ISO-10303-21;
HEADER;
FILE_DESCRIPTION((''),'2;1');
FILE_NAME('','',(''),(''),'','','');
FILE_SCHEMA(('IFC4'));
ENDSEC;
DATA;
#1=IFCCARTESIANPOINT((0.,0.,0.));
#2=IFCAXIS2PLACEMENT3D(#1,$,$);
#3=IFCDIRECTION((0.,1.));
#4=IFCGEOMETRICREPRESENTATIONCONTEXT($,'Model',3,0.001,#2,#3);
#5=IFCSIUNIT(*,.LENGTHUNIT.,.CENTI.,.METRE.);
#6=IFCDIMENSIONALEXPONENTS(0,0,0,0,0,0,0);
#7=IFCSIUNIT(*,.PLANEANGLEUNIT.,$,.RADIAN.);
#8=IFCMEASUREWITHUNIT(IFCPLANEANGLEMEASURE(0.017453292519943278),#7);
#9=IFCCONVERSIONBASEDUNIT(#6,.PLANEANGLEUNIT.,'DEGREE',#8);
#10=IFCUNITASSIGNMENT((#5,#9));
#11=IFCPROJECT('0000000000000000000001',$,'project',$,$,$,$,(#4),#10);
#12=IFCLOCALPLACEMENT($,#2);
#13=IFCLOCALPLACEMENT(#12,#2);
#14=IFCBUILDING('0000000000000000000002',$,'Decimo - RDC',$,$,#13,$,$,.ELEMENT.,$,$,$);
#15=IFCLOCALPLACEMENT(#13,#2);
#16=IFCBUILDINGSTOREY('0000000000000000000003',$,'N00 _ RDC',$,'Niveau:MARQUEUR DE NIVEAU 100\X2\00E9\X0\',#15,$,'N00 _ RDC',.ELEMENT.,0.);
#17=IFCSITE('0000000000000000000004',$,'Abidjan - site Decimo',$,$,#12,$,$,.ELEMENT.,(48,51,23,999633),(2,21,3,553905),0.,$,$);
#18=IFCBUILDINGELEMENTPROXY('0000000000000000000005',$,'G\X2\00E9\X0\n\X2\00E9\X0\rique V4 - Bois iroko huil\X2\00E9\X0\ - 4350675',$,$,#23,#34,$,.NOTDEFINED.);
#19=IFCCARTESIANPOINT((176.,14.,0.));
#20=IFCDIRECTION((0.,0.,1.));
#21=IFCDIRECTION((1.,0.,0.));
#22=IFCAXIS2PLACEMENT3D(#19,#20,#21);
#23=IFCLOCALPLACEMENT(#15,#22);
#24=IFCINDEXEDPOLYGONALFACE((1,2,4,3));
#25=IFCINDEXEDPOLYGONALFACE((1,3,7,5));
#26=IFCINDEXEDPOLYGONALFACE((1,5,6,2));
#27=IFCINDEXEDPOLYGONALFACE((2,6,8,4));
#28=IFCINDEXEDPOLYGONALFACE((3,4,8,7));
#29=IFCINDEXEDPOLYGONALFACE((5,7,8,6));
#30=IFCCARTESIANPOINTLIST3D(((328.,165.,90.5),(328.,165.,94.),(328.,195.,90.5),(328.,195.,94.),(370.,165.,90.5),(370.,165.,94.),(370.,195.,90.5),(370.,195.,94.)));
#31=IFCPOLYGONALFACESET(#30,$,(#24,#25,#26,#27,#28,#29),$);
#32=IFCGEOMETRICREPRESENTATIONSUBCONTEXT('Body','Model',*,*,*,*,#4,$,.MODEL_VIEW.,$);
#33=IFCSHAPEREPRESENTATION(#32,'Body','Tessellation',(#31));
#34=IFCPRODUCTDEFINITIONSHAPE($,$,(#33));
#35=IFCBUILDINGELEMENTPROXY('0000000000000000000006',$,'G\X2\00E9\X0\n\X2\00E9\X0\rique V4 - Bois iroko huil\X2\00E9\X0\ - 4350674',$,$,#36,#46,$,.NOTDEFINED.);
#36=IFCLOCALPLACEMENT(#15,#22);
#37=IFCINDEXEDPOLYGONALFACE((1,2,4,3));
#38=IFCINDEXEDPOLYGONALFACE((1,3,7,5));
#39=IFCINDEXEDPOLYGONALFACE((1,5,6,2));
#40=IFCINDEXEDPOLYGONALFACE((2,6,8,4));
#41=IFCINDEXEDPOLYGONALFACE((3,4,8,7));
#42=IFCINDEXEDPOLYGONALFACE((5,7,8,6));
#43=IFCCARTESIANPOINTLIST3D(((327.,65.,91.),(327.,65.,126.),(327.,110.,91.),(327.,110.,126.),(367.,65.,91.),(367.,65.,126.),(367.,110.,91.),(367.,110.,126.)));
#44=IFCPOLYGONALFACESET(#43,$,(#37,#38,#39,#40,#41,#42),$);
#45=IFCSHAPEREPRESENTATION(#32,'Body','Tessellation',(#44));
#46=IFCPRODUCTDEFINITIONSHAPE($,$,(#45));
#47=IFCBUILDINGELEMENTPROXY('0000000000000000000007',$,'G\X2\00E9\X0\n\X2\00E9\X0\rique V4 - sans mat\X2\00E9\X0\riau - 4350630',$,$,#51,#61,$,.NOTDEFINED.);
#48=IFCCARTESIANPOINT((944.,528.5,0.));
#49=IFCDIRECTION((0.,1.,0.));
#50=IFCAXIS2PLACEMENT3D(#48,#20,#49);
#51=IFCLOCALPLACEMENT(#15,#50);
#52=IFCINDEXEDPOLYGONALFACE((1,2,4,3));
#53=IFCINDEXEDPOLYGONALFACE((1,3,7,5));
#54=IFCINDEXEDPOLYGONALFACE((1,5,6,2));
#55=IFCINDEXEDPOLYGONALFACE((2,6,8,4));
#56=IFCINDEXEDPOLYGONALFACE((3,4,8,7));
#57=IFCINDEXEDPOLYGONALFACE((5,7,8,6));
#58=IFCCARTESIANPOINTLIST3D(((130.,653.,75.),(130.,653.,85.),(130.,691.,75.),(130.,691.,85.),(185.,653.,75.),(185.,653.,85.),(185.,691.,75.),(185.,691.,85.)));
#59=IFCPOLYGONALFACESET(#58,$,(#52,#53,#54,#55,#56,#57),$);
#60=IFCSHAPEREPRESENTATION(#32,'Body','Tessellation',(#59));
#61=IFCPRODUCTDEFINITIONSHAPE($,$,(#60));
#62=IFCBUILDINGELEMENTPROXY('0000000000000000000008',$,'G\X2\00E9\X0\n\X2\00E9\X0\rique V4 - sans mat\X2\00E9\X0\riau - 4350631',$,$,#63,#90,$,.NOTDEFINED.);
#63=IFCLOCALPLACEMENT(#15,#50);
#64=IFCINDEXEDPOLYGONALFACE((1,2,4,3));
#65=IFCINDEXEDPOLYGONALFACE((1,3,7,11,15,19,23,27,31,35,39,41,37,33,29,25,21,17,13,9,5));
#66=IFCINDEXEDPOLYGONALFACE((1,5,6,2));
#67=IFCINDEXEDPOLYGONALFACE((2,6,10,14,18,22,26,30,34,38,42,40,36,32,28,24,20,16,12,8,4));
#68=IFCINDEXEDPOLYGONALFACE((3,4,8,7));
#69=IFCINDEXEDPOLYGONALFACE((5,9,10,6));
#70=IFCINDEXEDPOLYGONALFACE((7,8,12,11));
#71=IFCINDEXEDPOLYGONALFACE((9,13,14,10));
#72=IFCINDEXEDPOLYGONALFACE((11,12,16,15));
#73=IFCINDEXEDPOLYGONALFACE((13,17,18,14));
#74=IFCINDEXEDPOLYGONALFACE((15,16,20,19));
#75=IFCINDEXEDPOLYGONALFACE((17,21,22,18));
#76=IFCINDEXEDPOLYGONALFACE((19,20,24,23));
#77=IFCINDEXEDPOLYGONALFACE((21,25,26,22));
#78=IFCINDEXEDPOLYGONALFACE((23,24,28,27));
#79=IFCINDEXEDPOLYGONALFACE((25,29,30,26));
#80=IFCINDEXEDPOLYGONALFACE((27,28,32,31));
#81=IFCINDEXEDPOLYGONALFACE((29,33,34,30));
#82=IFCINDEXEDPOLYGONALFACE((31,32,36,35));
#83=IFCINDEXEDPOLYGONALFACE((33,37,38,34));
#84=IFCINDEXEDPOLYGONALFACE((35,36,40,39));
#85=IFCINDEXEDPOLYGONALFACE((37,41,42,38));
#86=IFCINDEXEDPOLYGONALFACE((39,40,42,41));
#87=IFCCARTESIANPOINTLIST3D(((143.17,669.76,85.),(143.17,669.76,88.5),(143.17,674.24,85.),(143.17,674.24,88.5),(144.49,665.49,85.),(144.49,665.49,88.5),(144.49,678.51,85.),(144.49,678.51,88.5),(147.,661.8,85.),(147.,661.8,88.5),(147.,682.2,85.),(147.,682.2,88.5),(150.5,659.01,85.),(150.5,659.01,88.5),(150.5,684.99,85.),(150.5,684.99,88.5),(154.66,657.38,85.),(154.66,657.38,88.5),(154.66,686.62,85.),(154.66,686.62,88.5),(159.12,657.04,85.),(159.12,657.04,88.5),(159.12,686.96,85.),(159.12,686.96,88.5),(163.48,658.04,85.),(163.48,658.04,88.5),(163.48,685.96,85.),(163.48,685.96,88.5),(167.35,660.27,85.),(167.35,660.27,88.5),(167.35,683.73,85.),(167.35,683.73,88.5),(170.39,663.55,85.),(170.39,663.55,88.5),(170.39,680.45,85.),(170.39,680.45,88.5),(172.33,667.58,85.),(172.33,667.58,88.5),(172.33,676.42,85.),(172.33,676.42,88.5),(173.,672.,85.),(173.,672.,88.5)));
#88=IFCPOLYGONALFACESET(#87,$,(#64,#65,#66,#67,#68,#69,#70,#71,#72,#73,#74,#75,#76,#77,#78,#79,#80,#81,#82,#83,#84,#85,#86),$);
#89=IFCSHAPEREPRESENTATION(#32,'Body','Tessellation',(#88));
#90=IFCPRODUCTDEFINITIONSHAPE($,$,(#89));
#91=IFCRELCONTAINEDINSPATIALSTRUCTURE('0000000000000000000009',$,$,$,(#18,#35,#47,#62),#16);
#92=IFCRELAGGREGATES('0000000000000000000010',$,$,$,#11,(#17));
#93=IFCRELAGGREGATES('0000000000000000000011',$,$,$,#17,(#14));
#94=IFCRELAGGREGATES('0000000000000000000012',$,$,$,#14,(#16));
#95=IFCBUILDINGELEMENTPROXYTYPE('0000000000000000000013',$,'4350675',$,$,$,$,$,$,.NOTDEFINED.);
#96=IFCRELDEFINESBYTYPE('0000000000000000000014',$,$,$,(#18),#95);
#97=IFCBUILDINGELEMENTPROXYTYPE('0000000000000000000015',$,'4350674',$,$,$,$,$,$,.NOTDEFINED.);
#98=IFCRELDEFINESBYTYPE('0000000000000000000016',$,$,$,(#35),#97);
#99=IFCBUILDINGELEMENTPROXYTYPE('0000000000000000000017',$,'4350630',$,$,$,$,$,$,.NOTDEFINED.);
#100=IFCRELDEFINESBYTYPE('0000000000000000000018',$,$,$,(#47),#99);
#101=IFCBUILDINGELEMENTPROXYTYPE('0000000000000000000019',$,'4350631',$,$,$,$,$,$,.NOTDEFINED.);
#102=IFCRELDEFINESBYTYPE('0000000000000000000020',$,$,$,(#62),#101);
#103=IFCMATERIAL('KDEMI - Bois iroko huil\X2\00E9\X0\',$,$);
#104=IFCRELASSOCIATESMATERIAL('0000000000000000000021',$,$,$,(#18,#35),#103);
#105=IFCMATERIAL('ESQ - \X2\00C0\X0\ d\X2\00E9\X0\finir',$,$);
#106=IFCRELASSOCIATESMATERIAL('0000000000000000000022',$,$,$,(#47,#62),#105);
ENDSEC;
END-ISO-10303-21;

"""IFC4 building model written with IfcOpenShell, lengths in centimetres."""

from ifc_helpers import new_model, entity, si_unit, converted_unit, direction, frame, origin, origin_2d_with_axis, place, context, subcontext, project, spatial, rectangle, circle, extrude, material, type_object, element, save


model = new_model("IFC4")

# Units and contexts
model_context = context("Model", 3, precision=0.001, world=origin(), true_north=direction((0.0, 1.0)))
body_context = subcontext(model_context, "Body", "Model", "MODEL_VIEW")
ifc_project = project(units=[si_unit("LENGTHUNIT", "METRE", prefix="CENTI"), converted_unit("PLANEANGLEUNIT", "DEGREE", entity("IfcPlaneAngleMeasure", 0.017453292519943278), si_unit("PLANEANGLEUNIT", "RADIAN"), dimensions=[0, 0, 0, 0, 0, 0, 0])], contexts=[model_context])

# Site, building, storey
site_placement = place(None, origin())
site = spatial("IfcSite", under=ifc_project, at=site_placement, Name="Abidjan - site Decimo", CompositionType="ELEMENT", RefLatitude=(48, 51, 23, 999633), RefLongitude=(2, 21, 3, 553905), RefElevation=0.0)
building_placement = place(site_placement, origin())
building = spatial("IfcBuilding", under=site, at=building_placement, Name="Decimo - RDC", CompositionType="ELEMENT")
storey_placement = place(building_placement, origin())
storey = spatial("IfcBuildingStorey", under=building, at=storey_placement, Name="N00 _ RDC", ObjectType="Niveau:MARQUEUR DE NIVEAU 100é", LongName="N00 _ RDC", CompositionType="ELEMENT", Elevation=0.0)

# Shared definitions
ifc_material_1 = material(Name="KDEMI - Bois iroko huilé")

# Building element proxies
building_element_proxy_type_1 = type_object("IfcBuildingElementProxyType", Name="4350675", PredefinedType="NOTDEFINED")
proxy_1_placement = place(storey_placement, frame((176.0, 14.0, 0.0), z_axis=(0.0, 0.0, 1.0), x_axis=(1.0, 0.0, 0.0)))
element("IfcBuildingElementProxy", 1, at=proxy_1_placement, inside=storey, type_object=building_element_proxy_type_1, material=ifc_material_1, Name="Générique V4 - Bois iroko huilé - 4350675", PredefinedType="NOTDEFINED", context=body_context, shape_type="SweptSolid", body=[
    extrude(rectangle(XDim=42.0, YDim=30.0, at=origin_2d_with_axis()), frame((349.0, 180.0, 90.5)), (0.0, 0.0, 1.0), 3.5),
])
building_element_proxy_type_2 = type_object("IfcBuildingElementProxyType", Name="4350674", PredefinedType="NOTDEFINED")
proxy_2_placement = place(storey_placement, frame((176.0, 14.0, 0.0), z_axis=(0.0, 0.0, 1.0), x_axis=(1.0, 0.0, 0.0)))
element("IfcBuildingElementProxy", 2, at=proxy_2_placement, inside=storey, type_object=building_element_proxy_type_2, material=ifc_material_1, Name="Générique V4 - Bois iroko huilé - 4350674", PredefinedType="NOTDEFINED", context=body_context, shape_type="SweptSolid", body=[
    extrude(rectangle(XDim=40.0, YDim=45.0, at=origin_2d_with_axis()), frame((347.0, 87.5, 91.0)), (0.0, 0.0, 1.0), 35.0),
])
ifc_material_2 = material(Name="ESQ - À définir")
building_element_proxy_type_3 = type_object("IfcBuildingElementProxyType", Name="4350630", PredefinedType="NOTDEFINED")
proxy_3_placement = place(storey_placement, frame((944.0, 528.5, 0.0), z_axis=(0.0, 0.0, 1.0), x_axis=(0.0, 1.0, 0.0)))
element("IfcBuildingElementProxy", 3, at=proxy_3_placement, inside=storey, type_object=building_element_proxy_type_3, material=ifc_material_2, Name="Générique V4 - sans matériau - 4350630", PredefinedType="NOTDEFINED", context=body_context, shape_type="SweptSolid", body=[
    extrude(rectangle(XDim=55.0, YDim=38.0, at=origin_2d_with_axis()), frame((157.5, 672.0, 75.0)), (0.0, 0.0, 1.0), 10.0),
])
building_element_proxy_type_4 = type_object("IfcBuildingElementProxyType", Name="4350631", PredefinedType="NOTDEFINED")
proxy_4_placement = place(storey_placement, frame((944.0, 528.5, 0.0), z_axis=(0.0, 0.0, 1.0), x_axis=(0.0, 1.0, 0.0)))
element("IfcBuildingElementProxy", 4, at=proxy_4_placement, inside=storey, type_object=building_element_proxy_type_4, material=ifc_material_2, Name="Générique V4 - sans matériau - 4350631", PredefinedType="NOTDEFINED", context=body_context, shape_type="SweptSolid", body=[
    extrude(circle(Radius=15.0, at=origin_2d_with_axis()), frame((158.0, 672.0, 85.0)), (0.0, 0.0, 1.0), 3.5),
])

save(model, "model.ifc")
